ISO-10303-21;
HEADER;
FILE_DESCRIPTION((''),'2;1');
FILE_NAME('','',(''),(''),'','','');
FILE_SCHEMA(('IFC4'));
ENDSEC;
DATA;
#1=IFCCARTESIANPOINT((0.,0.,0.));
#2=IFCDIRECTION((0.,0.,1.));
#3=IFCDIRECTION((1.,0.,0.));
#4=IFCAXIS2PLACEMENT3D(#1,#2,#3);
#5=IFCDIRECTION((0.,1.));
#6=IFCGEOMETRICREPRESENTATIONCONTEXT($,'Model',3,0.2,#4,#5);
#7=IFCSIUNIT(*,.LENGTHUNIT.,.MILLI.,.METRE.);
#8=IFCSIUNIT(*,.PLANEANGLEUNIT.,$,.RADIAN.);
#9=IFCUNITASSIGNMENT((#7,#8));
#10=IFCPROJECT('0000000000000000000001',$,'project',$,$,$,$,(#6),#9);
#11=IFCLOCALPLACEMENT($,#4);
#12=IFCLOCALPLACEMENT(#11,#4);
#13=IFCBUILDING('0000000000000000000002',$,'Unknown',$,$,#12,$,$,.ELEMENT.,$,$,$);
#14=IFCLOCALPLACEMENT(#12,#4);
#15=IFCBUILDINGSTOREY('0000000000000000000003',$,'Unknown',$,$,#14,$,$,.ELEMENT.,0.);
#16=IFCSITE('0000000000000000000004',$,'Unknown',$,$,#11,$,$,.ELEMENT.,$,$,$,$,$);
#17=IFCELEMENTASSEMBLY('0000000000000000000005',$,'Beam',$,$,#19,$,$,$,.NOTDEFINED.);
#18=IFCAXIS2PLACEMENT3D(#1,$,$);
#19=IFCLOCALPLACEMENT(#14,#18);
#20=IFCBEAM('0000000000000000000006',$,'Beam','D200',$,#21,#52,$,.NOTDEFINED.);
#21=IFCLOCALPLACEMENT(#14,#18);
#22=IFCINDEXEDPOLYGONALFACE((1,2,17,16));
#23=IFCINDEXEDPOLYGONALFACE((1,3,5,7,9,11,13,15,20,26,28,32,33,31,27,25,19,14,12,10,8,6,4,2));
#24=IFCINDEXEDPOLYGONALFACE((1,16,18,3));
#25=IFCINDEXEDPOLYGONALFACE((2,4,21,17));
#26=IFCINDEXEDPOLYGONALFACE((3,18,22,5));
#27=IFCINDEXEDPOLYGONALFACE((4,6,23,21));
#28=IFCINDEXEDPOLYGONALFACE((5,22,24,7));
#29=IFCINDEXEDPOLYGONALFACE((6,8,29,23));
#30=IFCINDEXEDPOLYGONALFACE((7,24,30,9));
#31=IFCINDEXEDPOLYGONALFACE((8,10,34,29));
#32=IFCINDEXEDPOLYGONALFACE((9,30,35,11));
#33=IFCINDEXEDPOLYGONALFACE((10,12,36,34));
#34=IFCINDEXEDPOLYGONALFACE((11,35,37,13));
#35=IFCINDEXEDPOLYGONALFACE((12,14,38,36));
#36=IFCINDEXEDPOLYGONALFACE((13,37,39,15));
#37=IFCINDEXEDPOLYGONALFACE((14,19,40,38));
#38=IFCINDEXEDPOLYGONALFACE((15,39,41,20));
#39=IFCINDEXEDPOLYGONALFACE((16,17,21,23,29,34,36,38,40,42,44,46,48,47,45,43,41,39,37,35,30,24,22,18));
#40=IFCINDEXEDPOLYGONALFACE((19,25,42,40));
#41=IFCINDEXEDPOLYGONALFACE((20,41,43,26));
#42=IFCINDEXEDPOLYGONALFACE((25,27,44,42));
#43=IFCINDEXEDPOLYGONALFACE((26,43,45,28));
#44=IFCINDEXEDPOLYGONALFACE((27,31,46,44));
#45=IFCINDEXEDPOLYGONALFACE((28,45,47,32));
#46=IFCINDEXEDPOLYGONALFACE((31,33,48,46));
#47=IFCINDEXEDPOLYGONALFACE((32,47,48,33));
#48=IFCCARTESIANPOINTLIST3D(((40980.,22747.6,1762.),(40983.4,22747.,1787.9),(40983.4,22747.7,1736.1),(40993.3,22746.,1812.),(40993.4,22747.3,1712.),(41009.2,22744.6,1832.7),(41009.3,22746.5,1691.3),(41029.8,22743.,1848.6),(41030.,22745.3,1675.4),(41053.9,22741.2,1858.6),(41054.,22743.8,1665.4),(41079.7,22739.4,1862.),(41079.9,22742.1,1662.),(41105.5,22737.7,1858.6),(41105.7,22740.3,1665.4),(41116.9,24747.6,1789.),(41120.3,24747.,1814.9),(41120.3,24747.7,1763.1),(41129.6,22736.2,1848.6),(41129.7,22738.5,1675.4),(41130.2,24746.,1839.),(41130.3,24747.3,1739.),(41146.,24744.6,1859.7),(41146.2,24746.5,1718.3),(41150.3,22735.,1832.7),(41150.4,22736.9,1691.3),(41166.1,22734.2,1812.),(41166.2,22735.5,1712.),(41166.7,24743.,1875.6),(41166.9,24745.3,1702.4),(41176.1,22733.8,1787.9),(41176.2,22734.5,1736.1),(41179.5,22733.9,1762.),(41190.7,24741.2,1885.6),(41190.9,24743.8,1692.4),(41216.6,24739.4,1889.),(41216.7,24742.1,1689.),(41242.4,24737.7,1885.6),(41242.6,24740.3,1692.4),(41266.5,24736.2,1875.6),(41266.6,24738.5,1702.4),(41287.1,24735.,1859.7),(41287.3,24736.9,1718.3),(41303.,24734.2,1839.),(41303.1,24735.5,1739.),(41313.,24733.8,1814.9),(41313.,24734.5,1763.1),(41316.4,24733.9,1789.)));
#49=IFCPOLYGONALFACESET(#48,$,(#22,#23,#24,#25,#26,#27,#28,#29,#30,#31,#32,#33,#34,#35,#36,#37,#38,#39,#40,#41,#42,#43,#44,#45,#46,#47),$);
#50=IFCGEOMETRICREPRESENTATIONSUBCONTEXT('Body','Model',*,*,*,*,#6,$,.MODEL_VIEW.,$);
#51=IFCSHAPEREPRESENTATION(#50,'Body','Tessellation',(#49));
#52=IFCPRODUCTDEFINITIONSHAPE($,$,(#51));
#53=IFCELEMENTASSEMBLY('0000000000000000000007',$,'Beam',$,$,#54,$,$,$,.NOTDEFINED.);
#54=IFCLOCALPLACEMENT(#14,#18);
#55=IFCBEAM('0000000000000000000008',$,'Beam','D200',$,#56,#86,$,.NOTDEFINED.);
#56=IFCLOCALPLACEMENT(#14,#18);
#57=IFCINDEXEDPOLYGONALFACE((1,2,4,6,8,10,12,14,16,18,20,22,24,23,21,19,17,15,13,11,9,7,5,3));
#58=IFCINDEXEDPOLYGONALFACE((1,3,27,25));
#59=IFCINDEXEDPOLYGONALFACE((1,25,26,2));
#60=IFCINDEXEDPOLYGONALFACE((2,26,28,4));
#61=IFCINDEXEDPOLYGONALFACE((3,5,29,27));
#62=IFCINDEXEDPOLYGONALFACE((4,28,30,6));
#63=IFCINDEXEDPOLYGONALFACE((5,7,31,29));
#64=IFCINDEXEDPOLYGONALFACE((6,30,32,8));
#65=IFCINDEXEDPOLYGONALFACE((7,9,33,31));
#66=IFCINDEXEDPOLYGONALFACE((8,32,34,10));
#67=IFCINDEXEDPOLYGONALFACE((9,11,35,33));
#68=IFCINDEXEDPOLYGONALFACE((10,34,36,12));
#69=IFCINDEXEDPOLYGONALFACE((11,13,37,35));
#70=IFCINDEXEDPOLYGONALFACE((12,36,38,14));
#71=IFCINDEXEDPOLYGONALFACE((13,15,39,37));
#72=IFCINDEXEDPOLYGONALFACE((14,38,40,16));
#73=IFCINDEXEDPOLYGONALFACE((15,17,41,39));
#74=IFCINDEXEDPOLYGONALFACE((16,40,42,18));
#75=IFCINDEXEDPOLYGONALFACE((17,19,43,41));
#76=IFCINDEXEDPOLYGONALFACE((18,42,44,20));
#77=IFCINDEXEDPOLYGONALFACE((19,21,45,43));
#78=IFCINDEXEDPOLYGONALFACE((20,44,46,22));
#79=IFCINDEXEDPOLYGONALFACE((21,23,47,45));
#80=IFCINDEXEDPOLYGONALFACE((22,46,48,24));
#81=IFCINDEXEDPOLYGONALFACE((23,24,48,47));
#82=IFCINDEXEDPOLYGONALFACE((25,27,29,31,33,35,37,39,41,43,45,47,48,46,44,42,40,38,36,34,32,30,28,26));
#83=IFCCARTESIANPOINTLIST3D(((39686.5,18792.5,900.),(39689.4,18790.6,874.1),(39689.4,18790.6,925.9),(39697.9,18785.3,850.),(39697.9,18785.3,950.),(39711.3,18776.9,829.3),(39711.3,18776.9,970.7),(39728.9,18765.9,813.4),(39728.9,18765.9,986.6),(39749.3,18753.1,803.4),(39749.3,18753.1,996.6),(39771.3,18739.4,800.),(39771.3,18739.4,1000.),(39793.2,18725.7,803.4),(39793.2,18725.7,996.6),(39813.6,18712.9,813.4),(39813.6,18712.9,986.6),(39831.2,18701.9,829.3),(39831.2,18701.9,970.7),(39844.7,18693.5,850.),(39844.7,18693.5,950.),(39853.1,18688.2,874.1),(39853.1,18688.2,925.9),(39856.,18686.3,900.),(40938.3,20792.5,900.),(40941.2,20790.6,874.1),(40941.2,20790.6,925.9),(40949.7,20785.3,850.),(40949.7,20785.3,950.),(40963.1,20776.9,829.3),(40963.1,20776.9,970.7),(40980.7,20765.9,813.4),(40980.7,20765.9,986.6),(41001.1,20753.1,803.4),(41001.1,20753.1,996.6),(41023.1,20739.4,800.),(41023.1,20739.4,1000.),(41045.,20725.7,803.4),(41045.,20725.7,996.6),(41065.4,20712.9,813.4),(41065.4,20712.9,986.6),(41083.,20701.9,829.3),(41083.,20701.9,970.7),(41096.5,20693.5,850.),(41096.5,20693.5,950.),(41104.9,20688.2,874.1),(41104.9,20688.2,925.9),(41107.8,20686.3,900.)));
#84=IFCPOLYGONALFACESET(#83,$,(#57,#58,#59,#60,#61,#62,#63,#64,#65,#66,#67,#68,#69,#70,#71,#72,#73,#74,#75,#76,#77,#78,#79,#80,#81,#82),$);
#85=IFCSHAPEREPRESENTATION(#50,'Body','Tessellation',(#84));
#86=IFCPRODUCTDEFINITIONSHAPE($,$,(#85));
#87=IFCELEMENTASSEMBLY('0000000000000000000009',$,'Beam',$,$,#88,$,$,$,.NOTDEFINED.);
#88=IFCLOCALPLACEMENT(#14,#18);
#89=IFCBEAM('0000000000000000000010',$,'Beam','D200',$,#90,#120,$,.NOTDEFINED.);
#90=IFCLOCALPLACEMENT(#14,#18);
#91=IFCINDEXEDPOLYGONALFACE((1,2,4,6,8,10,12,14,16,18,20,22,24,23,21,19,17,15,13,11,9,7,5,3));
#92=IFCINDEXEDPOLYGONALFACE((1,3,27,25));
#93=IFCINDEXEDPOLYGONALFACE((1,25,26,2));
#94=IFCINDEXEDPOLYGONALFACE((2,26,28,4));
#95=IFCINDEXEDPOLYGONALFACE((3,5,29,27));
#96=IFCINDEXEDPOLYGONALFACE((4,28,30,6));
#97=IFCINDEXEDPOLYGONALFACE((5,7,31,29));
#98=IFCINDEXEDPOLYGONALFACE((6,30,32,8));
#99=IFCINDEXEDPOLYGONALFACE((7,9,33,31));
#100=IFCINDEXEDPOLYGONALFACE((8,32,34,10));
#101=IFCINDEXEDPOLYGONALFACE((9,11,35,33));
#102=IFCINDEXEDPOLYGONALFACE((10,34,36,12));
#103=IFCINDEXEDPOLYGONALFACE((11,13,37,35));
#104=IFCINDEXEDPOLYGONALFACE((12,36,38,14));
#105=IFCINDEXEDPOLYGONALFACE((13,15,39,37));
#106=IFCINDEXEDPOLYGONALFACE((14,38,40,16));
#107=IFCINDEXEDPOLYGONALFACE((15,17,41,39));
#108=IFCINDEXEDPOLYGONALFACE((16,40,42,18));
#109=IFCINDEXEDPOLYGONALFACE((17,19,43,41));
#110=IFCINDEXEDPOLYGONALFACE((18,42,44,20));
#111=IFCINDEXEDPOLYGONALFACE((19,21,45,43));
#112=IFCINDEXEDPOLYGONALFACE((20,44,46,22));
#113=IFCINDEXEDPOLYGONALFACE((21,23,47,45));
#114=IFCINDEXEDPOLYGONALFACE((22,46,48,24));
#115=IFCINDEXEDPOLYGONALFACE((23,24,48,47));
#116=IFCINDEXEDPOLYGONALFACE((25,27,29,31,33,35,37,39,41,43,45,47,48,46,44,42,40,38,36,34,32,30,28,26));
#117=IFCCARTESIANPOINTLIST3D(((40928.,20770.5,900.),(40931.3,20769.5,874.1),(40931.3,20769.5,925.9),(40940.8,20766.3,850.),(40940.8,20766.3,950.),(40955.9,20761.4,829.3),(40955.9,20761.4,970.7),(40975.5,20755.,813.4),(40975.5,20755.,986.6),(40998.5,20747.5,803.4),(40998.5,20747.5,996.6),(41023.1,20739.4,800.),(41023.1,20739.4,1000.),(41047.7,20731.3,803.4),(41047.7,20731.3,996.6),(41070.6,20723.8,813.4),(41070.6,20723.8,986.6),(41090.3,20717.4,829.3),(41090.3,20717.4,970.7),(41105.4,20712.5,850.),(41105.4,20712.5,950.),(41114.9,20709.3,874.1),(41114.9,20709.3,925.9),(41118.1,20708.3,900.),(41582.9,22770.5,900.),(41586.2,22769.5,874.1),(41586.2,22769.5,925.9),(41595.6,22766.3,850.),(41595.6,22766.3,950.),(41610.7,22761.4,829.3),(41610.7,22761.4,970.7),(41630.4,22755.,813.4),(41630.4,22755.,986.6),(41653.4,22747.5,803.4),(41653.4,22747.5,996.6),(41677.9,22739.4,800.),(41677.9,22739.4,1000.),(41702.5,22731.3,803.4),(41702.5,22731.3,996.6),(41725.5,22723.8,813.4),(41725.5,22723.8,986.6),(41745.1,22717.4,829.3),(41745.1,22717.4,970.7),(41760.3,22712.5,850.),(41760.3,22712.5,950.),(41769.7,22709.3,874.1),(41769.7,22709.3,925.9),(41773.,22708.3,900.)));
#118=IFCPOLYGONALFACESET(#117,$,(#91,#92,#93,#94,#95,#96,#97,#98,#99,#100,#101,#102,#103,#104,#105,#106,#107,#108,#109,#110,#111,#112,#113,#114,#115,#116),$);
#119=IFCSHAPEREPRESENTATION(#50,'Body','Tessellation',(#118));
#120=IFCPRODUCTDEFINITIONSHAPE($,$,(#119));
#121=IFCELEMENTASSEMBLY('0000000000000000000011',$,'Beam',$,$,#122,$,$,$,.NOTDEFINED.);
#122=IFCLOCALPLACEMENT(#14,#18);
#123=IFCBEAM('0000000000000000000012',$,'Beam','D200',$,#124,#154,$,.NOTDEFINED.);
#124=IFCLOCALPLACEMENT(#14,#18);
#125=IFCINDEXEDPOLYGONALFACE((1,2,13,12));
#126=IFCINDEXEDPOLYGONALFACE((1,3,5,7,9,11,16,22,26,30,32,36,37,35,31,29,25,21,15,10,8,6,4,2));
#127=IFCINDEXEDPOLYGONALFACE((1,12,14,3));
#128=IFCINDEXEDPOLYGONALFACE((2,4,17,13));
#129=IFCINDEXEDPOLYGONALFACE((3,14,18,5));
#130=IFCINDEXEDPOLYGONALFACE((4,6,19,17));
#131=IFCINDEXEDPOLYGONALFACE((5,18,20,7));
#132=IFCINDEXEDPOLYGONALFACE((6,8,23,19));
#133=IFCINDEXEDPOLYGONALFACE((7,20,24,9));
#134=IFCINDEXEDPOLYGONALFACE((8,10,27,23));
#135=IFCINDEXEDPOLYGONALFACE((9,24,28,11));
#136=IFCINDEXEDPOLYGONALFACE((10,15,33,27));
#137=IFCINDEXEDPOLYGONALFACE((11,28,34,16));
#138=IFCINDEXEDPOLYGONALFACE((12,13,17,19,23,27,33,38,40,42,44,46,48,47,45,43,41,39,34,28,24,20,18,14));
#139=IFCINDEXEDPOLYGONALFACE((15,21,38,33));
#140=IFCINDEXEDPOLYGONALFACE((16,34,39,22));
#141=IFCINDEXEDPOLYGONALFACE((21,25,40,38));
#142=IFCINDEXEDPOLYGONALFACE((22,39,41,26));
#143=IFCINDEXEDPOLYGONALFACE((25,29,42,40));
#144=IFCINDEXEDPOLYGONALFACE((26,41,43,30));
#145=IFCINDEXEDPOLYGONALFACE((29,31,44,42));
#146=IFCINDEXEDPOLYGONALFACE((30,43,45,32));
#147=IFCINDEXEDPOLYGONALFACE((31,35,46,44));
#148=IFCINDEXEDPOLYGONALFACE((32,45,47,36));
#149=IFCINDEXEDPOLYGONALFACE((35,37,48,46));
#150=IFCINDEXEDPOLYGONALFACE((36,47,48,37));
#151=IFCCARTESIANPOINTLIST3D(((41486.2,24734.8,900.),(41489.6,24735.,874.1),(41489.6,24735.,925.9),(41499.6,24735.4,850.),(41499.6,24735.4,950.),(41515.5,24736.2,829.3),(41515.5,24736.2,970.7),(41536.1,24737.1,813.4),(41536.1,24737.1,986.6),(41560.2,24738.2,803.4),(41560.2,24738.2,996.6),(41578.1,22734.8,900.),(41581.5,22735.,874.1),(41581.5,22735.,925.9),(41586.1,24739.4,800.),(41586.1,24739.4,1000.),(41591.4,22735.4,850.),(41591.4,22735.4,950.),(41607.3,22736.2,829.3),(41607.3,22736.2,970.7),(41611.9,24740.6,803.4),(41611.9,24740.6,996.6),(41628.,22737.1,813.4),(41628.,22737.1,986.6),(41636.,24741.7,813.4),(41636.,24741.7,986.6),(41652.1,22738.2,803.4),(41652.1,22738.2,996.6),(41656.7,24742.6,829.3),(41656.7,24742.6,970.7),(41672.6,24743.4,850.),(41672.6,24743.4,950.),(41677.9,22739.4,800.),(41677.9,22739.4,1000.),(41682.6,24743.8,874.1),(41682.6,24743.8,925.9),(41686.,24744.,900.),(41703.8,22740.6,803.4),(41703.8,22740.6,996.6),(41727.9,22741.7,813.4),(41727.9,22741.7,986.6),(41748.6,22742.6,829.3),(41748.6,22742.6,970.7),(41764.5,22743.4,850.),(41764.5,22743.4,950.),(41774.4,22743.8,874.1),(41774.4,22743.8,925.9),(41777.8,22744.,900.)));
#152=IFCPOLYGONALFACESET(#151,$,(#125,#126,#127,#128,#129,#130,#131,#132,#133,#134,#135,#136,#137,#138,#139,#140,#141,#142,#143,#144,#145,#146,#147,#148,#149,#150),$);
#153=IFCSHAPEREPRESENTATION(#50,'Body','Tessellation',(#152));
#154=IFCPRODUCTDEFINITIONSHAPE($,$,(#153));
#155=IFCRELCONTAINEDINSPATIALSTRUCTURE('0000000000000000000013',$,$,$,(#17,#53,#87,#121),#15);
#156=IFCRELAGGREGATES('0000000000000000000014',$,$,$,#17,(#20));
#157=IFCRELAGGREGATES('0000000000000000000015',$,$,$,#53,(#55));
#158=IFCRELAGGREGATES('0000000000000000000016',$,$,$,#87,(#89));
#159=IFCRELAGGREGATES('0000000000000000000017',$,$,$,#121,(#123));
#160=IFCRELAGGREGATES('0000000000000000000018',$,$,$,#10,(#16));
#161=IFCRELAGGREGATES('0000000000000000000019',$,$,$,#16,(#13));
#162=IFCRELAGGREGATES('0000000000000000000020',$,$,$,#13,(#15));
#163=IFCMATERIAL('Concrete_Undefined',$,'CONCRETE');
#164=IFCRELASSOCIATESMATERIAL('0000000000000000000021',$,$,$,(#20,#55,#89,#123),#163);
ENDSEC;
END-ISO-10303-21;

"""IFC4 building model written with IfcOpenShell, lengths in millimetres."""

from ifc_helpers import new_model, si_unit, direction, frame, origin_with_axes, place, context, subcontext, project, spatial, line, indexed_curve, outline, extrude, material, element, aggregate, save


model = new_model("IFC4")

# Units and contexts
model_context = context("Model", 3, precision=0.2, world=origin_with_axes(), true_north=direction((0.0, 1.0)))
body_context = subcontext(model_context, "Body", "Model", "MODEL_VIEW")
ifc_project = project(units=[si_unit("LENGTHUNIT", "METRE", prefix="MILLI"), si_unit("PLANEANGLEUNIT", "RADIAN")], contexts=[model_context])

# Site, building, storey
site_placement = place(None, origin_with_axes())
site = spatial("IfcSite", under=ifc_project, at=site_placement, Name="Unknown", CompositionType="ELEMENT")
building_placement = place(site_placement, origin_with_axes())
building = spatial("IfcBuilding", under=site, at=building_placement, Name="Unknown", CompositionType="ELEMENT")
storey_placement = place(building_placement, origin_with_axes())
storey = spatial("IfcBuildingStorey", under=building, at=storey_placement, Name="Unknown", CompositionType="ELEMENT", Elevation=0.0)

# Element assemblies, beams
ifc_material = material(Name="Concrete_Undefined", Category="CONCRETE")
assembly_1_placement = place(storey_placement, frame((41216.7, 24740.7, 1789.0), z_axis=(-0.997666, 0.068278, 0.0), x_axis=(-0.068272, -0.997576, -0.013479)))
assembly_1 = element("IfcElementAssembly", 1, at=assembly_1_placement, inside=storey, Name="Beam", PredefinedType="NOTDEFINED")
beam_1_placement = place(assembly_1_placement, origin_with_axes())
beam_1 = element("IfcBeam", 2, at=beam_1_placement, material=ifc_material, Name="Beam", Description="D200", PredefinedType="NOTDEFINED", context=body_context, shape_type="SolidModel", body=[
    extrude(outline(indexed_curve([(100.0, 0.0), (96.6, 25.9), (86.6, 50.0), (70.7, 70.7), (50.0, 86.6), (25.9, 96.6), (0.0, 100.0), (-25.9, 96.6), (-50.0, 86.6), (-70.7, 70.7), (-86.6, 50.0), (-96.6, 25.9), (-100.0, 0.0), (-96.6, -25.9), (-86.6, -50.0), (-70.7, -70.7), (-50.0, -86.6), (-25.9, -96.6), (0.0, -100.0), (25.9, -96.6), (50.0, -86.6), (70.7, -70.7), (86.6, -50.0), (96.6, -25.9)], segments=[line(1, 2, 3, 4, 5, 6, 7, 8, 9, 10, 11, 12, 13, 14, 15, 16, 17, 18, 19, 20, 21, 22, 23, 24, 1)])), frame((0.0, 0.0, 0.0), z_axis=(-1.0, 0.0, 0.0), x_axis=(0.0, 0.0, 1.0)), (0.0, 0.0, -1.0), 2004.9),
])
aggregate(assembly_1, [beam_1])
assembly_2_placement = place(storey_placement, frame((41023.1, 20739.4, 900.0), z_axis=(-0.847655, 0.530547, 0.0), x_axis=(-0.530547, -0.847655, 0.0)))
assembly_2 = element("IfcElementAssembly", 3, at=assembly_2_placement, inside=storey, Name="Beam", PredefinedType="NOTDEFINED")
beam_2_placement = place(assembly_2_placement, origin_with_axes())
beam_2 = element("IfcBeam", 4, at=beam_2_placement, material=ifc_material, Name="Beam", Description="D200", PredefinedType="NOTDEFINED", context=body_context, shape_type="SolidModel", body=[
    extrude(outline(indexed_curve([(100.0, 0.0), (96.6, 25.9), (86.6, 50.0), (70.7, 70.7), (50.0, 86.6), (25.9, 96.6), (0.0, 100.0), (-25.9, 96.6), (-50.0, 86.6), (-70.7, 70.7), (-86.6, 50.0), (-96.6, 25.9), (-100.0, 0.0), (-96.6, -25.9), (-86.6, -50.0), (-70.7, -70.7), (-50.0, -86.6), (-25.9, -96.6), (0.0, -100.0), (25.9, -96.6), (50.0, -86.6), (70.7, -70.7), (86.6, -50.0), (96.6, -25.9)], segments=[line(1, 2, 3, 4, 5, 6, 7, 8, 9, 10, 11, 12, 13, 14, 15, 16, 17, 18, 19, 20, 21, 22, 23, 24, 1)])), frame((0.0, 0.0, 0.0), z_axis=(-1.0, 0.0, 0.0), x_axis=(0.0, 0.0, 1.0)), (0.0, 0.0, -1.0), 2359.4),
])
aggregate(assembly_2, [beam_2])
assembly_3_placement = place(storey_placement, frame((41677.9, 22739.4, 900.0), z_axis=(-0.950349, 0.311185, 0.0), x_axis=(-0.311185, -0.950349, 0.0)))
assembly_3 = element("IfcElementAssembly", 5, at=assembly_3_placement, inside=storey, Name="Beam", PredefinedType="NOTDEFINED")
beam_3_placement = place(assembly_3_placement, origin_with_axes())
beam_3 = element("IfcBeam", 6, at=beam_3_placement, material=ifc_material, Name="Beam", Description="D200", PredefinedType="NOTDEFINED", context=body_context, shape_type="SolidModel", body=[
    extrude(outline(indexed_curve([(100.0, 0.0), (96.6, 25.9), (86.6, 50.0), (70.7, 70.7), (50.0, 86.6), (25.9, 96.6), (0.0, 100.0), (-25.9, 96.6), (-50.0, 86.6), (-70.7, 70.7), (-86.6, 50.0), (-96.6, 25.9), (-100.0, 0.0), (-96.6, -25.9), (-86.6, -50.0), (-70.7, -70.7), (-50.0, -86.6), (-25.9, -96.6), (0.0, -100.0), (25.9, -96.6), (50.0, -86.6), (70.7, -70.7), (86.6, -50.0), (96.6, -25.9)], segments=[line(1, 2, 3, 4, 5, 6, 7, 8, 9, 10, 11, 12, 13, 14, 15, 16, 17, 18, 19, 20, 21, 22, 23, 24, 1)])), frame((0.0, 0.0, 0.0), z_axis=(-1.0, 0.0, 0.0), x_axis=(0.0, 0.0, 1.0)), (0.0, 0.0, -1.0), 2104.5),
])
aggregate(assembly_3, [beam_3])
assembly_4_placement = place(storey_placement, frame((41586.1, 24739.4, 900.0), z_axis=(-0.998947, -0.04588, 0.0), x_axis=(0.04588, -0.998947, 0.0)))
assembly_4 = element("IfcElementAssembly", 7, at=assembly_4_placement, inside=storey, Name="Beam", PredefinedType="NOTDEFINED")
beam_4_placement = place(assembly_4_placement, origin_with_axes())
beam_4 = element("IfcBeam", 8, at=beam_4_placement, material=ifc_material, Name="Beam", Description="D200", PredefinedType="NOTDEFINED", context=body_context, shape_type="SolidModel", body=[
    extrude(outline(indexed_curve([(100.0, 0.0), (96.6, 25.9), (86.6, 50.0), (70.7, 70.7), (50.0, 86.6), (25.9, 96.6), (0.0, 100.0), (-25.9, 96.6), (-50.0, 86.6), (-70.7, 70.7), (-86.6, 50.0), (-96.6, 25.9), (-100.0, 0.0), (-96.6, -25.9), (-86.6, -50.0), (-70.7, -70.7), (-50.0, -86.6), (-25.9, -96.6), (0.0, -100.0), (25.9, -96.6), (50.0, -86.6), (70.7, -70.7), (86.6, -50.0), (96.6, -25.9)], segments=[line(1, 2, 3, 4, 5, 6, 7, 8, 9, 10, 11, 12, 13, 14, 15, 16, 17, 18, 19, 20, 21, 22, 23, 24, 1)])), frame((0.0, 0.0, 0.0), z_axis=(-1.0, 0.0, 0.0), x_axis=(0.0, 0.0, 1.0)), (0.0, 0.0, -1.0), 2002.1),
])
aggregate(assembly_4, [beam_4])

save(model, "model.ifc")
